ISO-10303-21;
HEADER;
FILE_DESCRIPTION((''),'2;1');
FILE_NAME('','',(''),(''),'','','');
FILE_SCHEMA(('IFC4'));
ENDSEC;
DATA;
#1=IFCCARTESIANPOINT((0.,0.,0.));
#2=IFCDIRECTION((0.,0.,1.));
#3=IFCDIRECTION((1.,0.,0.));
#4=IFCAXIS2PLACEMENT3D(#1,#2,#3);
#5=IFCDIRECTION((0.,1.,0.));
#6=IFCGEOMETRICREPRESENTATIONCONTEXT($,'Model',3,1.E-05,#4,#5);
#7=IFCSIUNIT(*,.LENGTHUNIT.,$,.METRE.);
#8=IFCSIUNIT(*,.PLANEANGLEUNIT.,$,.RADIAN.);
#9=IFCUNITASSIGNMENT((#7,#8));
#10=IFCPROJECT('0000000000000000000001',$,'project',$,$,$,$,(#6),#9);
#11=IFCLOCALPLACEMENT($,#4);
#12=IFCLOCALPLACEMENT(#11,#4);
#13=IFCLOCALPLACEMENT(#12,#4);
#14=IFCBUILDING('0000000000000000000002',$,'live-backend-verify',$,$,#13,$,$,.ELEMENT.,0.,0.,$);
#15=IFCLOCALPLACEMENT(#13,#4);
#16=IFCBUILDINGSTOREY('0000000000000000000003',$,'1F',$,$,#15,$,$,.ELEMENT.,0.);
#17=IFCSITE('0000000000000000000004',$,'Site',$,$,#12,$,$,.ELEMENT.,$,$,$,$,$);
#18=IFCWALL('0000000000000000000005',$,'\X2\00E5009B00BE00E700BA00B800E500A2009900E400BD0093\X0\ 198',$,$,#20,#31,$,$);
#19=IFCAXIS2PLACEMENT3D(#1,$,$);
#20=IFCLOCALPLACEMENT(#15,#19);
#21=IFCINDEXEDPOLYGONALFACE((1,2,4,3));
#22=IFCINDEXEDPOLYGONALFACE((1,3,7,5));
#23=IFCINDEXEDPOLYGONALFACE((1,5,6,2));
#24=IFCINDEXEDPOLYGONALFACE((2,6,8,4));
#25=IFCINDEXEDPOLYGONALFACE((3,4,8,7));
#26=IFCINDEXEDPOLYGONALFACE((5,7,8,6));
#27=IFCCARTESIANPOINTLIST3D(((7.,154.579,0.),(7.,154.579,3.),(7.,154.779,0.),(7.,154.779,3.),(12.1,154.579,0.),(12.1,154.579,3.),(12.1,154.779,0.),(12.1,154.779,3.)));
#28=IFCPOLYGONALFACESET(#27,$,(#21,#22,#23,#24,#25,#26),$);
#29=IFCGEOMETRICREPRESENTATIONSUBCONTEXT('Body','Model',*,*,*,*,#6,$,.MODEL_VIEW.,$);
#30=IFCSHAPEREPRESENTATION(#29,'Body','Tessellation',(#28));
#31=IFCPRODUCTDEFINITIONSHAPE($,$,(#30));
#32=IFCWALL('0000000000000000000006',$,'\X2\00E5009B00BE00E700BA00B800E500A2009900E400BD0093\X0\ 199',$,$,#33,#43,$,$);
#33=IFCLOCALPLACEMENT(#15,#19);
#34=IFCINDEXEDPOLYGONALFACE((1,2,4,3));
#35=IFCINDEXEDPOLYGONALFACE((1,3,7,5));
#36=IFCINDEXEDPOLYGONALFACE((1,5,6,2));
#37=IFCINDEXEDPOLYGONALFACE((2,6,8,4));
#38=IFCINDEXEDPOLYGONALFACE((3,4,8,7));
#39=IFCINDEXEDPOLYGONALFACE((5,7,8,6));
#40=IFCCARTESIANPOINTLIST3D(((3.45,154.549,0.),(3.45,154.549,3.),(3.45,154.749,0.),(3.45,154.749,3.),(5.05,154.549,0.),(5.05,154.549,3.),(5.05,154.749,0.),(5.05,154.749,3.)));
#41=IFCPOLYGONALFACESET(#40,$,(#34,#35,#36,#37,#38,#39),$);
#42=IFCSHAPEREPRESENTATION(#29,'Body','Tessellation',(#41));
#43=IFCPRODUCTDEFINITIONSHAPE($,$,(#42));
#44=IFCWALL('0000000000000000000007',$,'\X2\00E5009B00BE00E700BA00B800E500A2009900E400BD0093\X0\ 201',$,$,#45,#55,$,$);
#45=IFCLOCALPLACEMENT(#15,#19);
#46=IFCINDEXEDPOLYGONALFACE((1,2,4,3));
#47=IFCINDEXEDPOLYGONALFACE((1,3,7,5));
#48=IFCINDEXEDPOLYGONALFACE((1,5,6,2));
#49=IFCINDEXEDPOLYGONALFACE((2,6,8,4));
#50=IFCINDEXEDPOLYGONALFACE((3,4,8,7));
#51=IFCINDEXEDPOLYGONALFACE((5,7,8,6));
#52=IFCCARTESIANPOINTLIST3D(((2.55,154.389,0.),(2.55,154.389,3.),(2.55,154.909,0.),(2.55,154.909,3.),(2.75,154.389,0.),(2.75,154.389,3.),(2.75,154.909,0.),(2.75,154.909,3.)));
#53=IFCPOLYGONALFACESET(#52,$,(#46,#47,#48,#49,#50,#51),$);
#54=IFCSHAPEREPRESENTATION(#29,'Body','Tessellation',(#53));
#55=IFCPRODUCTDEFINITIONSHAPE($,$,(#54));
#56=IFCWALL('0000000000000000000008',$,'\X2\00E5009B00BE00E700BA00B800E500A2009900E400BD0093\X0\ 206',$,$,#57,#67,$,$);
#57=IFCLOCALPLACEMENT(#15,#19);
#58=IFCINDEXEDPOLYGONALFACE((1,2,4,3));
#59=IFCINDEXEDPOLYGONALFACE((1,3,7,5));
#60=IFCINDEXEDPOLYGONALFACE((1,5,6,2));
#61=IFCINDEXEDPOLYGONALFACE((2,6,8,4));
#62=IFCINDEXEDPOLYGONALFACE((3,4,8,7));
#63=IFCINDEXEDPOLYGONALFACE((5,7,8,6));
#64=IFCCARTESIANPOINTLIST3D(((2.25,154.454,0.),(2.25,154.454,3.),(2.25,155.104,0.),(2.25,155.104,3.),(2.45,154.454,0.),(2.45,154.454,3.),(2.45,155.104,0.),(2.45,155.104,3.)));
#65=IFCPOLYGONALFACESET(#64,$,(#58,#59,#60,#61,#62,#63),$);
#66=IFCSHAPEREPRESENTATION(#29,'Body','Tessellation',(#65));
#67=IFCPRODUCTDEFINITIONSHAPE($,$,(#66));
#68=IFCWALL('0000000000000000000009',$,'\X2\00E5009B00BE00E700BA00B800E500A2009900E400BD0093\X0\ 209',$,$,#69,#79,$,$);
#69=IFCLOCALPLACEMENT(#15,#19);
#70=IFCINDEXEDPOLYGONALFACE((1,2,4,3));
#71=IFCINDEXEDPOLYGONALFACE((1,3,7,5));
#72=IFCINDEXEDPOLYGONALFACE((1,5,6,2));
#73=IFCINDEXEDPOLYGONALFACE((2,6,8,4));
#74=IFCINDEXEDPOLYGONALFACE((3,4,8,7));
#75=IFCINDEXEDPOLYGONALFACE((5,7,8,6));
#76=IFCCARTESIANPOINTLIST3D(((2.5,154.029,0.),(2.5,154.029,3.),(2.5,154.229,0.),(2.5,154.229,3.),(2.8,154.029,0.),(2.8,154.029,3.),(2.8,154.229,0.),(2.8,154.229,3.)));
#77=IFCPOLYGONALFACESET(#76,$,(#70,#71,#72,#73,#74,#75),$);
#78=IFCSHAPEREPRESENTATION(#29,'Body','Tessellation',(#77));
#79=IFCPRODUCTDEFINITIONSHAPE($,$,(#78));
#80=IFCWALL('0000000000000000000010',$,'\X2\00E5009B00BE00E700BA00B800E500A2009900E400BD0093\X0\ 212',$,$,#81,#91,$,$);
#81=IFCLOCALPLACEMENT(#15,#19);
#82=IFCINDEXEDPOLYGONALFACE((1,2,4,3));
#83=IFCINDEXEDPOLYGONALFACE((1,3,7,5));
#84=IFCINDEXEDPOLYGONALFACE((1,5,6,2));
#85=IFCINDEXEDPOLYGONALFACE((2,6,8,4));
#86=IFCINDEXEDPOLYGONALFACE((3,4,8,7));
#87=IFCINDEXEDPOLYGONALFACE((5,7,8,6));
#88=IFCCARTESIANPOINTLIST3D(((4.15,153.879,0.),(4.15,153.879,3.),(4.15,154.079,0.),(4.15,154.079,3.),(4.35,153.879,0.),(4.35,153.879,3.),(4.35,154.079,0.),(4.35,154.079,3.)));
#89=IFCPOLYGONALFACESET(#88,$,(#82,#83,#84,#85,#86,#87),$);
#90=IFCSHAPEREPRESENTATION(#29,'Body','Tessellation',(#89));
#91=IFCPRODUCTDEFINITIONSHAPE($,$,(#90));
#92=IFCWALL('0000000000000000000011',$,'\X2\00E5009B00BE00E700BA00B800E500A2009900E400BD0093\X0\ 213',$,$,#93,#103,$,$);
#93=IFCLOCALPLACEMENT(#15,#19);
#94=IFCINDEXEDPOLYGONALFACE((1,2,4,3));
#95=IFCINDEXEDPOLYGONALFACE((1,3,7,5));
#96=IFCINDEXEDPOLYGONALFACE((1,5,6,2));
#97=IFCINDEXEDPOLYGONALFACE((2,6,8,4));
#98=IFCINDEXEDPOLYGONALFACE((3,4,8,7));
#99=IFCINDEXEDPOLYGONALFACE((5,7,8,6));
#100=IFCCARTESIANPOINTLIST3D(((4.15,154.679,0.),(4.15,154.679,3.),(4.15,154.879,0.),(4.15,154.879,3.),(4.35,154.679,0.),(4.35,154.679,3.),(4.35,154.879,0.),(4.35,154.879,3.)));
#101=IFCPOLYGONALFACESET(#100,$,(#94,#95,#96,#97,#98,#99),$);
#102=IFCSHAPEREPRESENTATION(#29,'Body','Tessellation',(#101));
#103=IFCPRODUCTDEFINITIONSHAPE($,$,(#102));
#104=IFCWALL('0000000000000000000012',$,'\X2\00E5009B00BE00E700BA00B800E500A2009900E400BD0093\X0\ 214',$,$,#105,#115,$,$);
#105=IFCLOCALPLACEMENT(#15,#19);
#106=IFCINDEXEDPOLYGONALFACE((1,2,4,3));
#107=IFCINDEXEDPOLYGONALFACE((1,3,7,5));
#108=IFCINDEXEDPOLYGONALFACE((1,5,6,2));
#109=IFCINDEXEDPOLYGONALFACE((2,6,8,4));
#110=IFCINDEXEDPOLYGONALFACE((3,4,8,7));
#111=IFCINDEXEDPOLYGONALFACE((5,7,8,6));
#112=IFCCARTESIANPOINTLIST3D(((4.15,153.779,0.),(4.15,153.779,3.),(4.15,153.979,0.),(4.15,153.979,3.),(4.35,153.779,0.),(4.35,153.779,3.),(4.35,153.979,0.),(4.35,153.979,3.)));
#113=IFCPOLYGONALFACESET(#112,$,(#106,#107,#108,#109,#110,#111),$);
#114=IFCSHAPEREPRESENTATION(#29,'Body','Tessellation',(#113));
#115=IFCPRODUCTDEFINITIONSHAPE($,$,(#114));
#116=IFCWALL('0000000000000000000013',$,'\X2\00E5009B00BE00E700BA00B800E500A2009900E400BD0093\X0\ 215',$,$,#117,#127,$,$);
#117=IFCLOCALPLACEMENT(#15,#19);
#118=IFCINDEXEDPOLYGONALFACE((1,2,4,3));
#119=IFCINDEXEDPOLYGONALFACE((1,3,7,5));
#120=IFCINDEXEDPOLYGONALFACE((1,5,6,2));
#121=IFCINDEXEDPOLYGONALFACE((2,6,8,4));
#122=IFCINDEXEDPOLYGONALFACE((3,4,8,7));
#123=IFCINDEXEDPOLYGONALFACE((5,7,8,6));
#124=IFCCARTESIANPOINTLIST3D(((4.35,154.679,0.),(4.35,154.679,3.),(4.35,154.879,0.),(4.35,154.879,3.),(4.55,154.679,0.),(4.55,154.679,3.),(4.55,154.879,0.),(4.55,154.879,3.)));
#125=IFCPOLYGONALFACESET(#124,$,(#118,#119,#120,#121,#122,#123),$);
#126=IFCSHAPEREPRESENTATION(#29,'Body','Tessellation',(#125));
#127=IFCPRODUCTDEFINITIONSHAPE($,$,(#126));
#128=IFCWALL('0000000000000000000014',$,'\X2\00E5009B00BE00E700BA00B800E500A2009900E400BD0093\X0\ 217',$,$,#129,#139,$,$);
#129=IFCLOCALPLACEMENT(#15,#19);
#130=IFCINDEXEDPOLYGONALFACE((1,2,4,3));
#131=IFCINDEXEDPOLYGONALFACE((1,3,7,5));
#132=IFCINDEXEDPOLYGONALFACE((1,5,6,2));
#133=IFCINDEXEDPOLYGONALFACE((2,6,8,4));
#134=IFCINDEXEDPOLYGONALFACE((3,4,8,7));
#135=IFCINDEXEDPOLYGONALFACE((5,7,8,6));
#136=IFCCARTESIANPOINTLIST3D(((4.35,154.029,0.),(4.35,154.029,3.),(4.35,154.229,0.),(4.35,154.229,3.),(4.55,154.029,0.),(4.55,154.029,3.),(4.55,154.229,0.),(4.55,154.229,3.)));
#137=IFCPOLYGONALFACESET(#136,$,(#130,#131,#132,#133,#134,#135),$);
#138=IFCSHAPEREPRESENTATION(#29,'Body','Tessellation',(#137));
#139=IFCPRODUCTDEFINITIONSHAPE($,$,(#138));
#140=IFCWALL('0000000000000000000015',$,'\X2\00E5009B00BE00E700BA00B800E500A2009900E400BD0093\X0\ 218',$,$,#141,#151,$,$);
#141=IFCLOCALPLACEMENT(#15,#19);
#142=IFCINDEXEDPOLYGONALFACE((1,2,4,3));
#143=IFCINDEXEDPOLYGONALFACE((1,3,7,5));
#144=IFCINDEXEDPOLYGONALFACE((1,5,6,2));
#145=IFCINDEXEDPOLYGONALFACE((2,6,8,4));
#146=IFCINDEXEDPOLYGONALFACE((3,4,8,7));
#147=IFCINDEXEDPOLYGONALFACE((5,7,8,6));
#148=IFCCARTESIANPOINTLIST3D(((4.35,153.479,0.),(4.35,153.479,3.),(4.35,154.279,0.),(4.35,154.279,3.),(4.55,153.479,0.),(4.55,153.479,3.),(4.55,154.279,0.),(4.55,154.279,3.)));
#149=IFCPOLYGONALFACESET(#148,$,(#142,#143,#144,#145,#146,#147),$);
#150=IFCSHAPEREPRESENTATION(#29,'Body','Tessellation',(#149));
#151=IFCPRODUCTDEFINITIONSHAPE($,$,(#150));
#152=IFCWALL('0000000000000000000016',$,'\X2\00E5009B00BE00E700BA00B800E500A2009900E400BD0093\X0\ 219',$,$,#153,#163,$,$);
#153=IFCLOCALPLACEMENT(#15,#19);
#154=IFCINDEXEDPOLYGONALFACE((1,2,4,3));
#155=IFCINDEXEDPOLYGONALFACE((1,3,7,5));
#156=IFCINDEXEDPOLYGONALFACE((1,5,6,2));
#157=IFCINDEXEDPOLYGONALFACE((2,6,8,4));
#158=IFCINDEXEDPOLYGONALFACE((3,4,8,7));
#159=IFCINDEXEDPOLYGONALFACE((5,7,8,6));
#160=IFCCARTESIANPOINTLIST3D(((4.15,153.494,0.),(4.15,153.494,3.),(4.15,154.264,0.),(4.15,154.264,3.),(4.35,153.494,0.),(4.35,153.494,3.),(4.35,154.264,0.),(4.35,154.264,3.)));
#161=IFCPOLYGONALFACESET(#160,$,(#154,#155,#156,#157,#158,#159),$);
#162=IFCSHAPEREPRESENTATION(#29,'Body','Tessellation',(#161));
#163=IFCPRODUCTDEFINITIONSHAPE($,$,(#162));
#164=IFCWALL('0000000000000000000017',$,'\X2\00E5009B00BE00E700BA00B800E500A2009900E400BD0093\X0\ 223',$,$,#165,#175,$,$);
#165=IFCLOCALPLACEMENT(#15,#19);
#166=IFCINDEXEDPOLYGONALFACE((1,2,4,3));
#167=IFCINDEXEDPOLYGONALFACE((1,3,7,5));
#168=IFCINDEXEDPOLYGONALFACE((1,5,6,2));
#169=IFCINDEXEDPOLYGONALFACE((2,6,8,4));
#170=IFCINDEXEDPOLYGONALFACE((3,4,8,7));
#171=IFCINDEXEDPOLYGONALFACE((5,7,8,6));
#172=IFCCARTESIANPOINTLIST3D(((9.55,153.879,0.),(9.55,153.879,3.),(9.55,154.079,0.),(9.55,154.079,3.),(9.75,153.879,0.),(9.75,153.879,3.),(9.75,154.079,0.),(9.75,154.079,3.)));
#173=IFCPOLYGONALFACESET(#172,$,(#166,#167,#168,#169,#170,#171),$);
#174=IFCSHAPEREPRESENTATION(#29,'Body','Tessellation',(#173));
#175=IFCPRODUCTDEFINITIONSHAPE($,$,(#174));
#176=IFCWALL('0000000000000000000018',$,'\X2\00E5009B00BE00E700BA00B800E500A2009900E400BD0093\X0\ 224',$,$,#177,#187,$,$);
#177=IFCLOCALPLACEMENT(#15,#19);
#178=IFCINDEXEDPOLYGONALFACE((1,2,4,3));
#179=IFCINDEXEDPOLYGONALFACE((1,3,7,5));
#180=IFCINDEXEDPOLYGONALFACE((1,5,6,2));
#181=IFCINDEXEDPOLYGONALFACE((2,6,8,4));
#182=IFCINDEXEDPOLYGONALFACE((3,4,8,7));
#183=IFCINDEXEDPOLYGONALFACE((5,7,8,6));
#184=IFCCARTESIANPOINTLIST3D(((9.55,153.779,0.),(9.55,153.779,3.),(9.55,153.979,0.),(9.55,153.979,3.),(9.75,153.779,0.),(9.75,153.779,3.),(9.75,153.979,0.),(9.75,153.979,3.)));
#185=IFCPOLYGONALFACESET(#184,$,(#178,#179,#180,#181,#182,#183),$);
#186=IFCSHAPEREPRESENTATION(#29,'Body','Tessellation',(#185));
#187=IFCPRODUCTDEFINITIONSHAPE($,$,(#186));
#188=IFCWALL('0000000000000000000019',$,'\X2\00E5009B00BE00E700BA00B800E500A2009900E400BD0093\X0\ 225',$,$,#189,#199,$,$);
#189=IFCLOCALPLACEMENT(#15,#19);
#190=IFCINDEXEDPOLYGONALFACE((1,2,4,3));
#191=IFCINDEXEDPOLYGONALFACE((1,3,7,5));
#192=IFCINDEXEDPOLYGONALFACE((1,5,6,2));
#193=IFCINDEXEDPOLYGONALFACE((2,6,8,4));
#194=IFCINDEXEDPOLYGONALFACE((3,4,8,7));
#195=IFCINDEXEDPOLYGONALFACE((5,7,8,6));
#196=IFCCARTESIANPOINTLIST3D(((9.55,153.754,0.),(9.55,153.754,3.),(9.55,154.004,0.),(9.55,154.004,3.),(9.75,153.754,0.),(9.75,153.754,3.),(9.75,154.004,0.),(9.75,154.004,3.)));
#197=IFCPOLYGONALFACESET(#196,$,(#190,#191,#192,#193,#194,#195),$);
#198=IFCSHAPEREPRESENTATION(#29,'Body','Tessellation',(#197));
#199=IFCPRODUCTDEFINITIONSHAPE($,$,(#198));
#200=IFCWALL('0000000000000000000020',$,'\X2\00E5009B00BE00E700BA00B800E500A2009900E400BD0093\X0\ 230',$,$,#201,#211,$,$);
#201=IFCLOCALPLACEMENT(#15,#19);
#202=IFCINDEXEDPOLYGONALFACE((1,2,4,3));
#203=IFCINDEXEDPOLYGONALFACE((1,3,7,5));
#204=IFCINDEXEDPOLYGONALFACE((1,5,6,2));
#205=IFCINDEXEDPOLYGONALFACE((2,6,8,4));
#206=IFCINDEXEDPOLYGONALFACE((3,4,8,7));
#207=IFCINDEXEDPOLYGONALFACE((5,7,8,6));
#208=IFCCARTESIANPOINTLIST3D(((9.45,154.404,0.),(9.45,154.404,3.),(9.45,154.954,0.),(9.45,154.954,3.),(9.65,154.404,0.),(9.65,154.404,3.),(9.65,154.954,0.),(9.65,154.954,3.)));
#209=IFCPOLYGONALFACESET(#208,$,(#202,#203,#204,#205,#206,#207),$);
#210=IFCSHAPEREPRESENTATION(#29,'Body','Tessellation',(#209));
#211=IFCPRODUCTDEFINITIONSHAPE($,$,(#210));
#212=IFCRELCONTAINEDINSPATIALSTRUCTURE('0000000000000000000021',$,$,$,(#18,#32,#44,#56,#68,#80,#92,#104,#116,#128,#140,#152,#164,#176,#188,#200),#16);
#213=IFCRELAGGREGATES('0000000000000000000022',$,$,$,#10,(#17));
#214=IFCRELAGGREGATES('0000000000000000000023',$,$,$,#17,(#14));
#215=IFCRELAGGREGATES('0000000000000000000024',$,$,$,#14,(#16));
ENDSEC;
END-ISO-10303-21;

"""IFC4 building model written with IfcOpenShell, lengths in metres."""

from ifc_helpers import new_model, si_unit, direction, frame, frame_2d, origin_with_axes, place, context, subcontext, project, spatial, rectangle, extrude, element, save


model = new_model("IFC4")

# Units and contexts
model_context = context("Model", 3, precision=1e-05, world=origin_with_axes(), true_north=direction((0.0, 1.0, 0.0)))
body_context = subcontext(model_context, "Body", "Model", "MODEL_VIEW")
ifc_project = project(units=[si_unit("LENGTHUNIT", "METRE"), si_unit("PLANEANGLEUNIT", "RADIAN")], contexts=[model_context])

# Site, building, storey
placement = place(None, origin_with_axes())
site_placement = place(placement, origin_with_axes())
site = spatial("IfcSite", under=ifc_project, at=site_placement, Name="Site", CompositionType="ELEMENT")
building_placement = place(site_placement, origin_with_axes())
building = spatial("IfcBuilding", under=site, at=building_placement, Name="live-backend-verify", CompositionType="ELEMENT", ElevationOfRefHeight=0.0, ElevationOfTerrain=0.0)
storey_placement = place(building_placement, origin_with_axes())
storey = spatial("IfcBuildingStorey", under=building, at=storey_placement, Name="1F", CompositionType="ELEMENT", Elevation=0.0)

# Walls
wall_1_placement = place(storey_placement, frame((9.55, 154.679, 0.0), z_axis=(0.0, 0.0, 1.0), x_axis=(-1.0, 0.0, 0.0)))
element("IfcWall", 1, at=wall_1_placement, inside=storey, Name="å\u009b¾çº¸å¢\u0099ä½\u0093 198", context=body_context, shape_type="SweptSolid", body=[
    extrude(rectangle(XDim=5.1, YDim=0.2, at=frame_2d((0.0, 0.0), x_axis=(1.0, 0.0, 0.0))), frame((0.0, 0.0, 0.0), z_axis=(0.0, 0.0, 1.0)), (0.0, 0.0, 1.0), 3.0),
])
wall_2_placement = place(storey_placement, frame((4.25, 154.649, 0.0), z_axis=(0.0, 0.0, 1.0), x_axis=(-1.0, 0.0, 0.0)))
element("IfcWall", 2, at=wall_2_placement, inside=storey, Name="å\u009b¾çº¸å¢\u0099ä½\u0093 199", context=body_context, shape_type="SweptSolid", body=[
    extrude(rectangle(XDim=1.6, YDim=0.2, at=frame_2d((0.0, 0.0), x_axis=(1.0, 0.0, 0.0))), frame((0.0, 0.0, 0.0), z_axis=(0.0, 0.0, 1.0)), (0.0, 0.0, 1.0), 3.0),
])
wall_3_placement = place(storey_placement, frame((2.65, 154.649, 0.0), z_axis=(0.0, 0.0, 1.0), x_axis=(0.0, -1.0, 0.0)))
element("IfcWall", 3, at=wall_3_placement, inside=storey, Name="å\u009b¾çº¸å¢\u0099ä½\u0093 201", context=body_context, shape_type="SweptSolid", body=[
    extrude(rectangle(XDim=0.52, YDim=0.2, at=frame_2d((0.0, 0.0), x_axis=(1.0, 0.0, 0.0))), frame((0.0, 0.0, 0.0), z_axis=(0.0, 0.0, 1.0)), (0.0, 0.0, 1.0), 3.0),
])
wall_4_placement = place(storey_placement, frame((2.35, 154.779, 0.0), z_axis=(0.0, 0.0, 1.0), x_axis=(0.0, -1.0, 0.0)))
element("IfcWall", 4, at=wall_4_placement, inside=storey, Name="å\u009b¾çº¸å¢\u0099ä½\u0093 206", context=body_context, shape_type="SweptSolid", body=[
    extrude(rectangle(XDim=0.65, YDim=0.2, at=frame_2d((0.0, 0.0), x_axis=(1.0, 0.0, 0.0))), frame((0.0, 0.0, 0.0), z_axis=(0.0, 0.0, 1.0)), (0.0, 0.0, 1.0), 3.0),
])
wall_5_placement = place(storey_placement, frame((2.65, 154.129, 0.0), z_axis=(0.0, 0.0, 1.0), x_axis=(-1.0, 0.0, 0.0)))
element("IfcWall", 5, at=wall_5_placement, inside=storey, Name="å\u009b¾çº¸å¢\u0099ä½\u0093 209", context=body_context, shape_type="SweptSolid", body=[
    extrude(rectangle(XDim=0.3, YDim=0.2, at=frame_2d((0.0, 0.0), x_axis=(1.0, 0.0, 0.0))), frame((0.0, 0.0, 0.0), z_axis=(0.0, 0.0, 1.0)), (0.0, 0.0, 1.0), 3.0),
])
for number, where, z_axis, x_axis, name in (
    (6, (4.25, 153.979, 0.0), (0.0, 0.0, 1.0), (1.0, 0.0, 0.0), "å\u009b¾çº¸å¢\u0099ä½\u0093 212"),
    (7, (4.25, 154.779, 0.0), (0.0, 0.0, 1.0), (1.0, 0.0, 0.0), "å\u009b¾çº¸å¢\u0099ä½\u0093 213"),
    (8, (4.25, 153.879, 0.0), (0.0, 0.0, 1.0), (1.0, 0.0, 0.0), "å\u009b¾çº¸å¢\u0099ä½\u0093 214"),
    (9, (4.45, 154.779, 0.0), (0.0, 0.0, 1.0), (-1.0, 0.0, 0.0), "å\u009b¾çº¸å¢\u0099ä½\u0093 215"),
    (10, (4.45, 154.129, 0.0), (0.0, 0.0, 1.0), (-1.0, 0.0, 0.0), "å\u009b¾çº¸å¢\u0099ä½\u0093 217"),
):
    element("IfcWall", number, at=place(storey_placement, frame(where, z_axis=z_axis, x_axis=x_axis)), inside=storey, Name=name, context=body_context, shape_type="SweptSolid", body=[
        extrude(rectangle(XDim=0.2, YDim=0.2, at=frame_2d((0.0, 0.0), x_axis=(1.0, 0.0, 0.0))), frame((0.0, 0.0, 0.0), z_axis=(0.0, 0.0, 1.0)), (0.0, 0.0, 1.0), 3.0),
    ])
wall_6_placement = place(storey_placement, frame((4.45, 153.879, 0.0), z_axis=(0.0, 0.0, 1.0), x_axis=(0.0, 1.0, 0.0)))
element("IfcWall", 11, at=wall_6_placement, inside=storey, Name="å\u009b¾çº¸å¢\u0099ä½\u0093 218", context=body_context, shape_type="SweptSolid", body=[
    extrude(rectangle(XDim=0.8, YDim=0.2, at=frame_2d((0.0, 0.0), x_axis=(1.0, 0.0, 0.0))), frame((0.0, 0.0, 0.0), z_axis=(0.0, 0.0, 1.0)), (0.0, 0.0, 1.0), 3.0),
])
wall_7_placement = place(storey_placement, frame((4.25, 153.879, 0.0), z_axis=(0.0, 0.0, 1.0), x_axis=(0.0, 1.0, 0.0)))
element("IfcWall", 12, at=wall_7_placement, inside=storey, Name="å\u009b¾çº¸å¢\u0099ä½\u0093 219", context=body_context, shape_type="SweptSolid", body=[
    extrude(rectangle(XDim=0.77, YDim=0.2, at=frame_2d((0.0, 0.0), x_axis=(1.0, 0.0, 0.0))), frame((0.0, 0.0, 0.0), z_axis=(0.0, 0.0, 1.0)), (0.0, 0.0, 1.0), 3.0),
])
for number, where, z_axis, x_axis, name in (
    (13, (9.65, 153.979, 0.0), (0.0, 0.0, 1.0), (1.0, 0.0, 0.0), "å\u009b¾çº¸å¢\u0099ä½\u0093 223"),
    (14, (9.65, 153.879, 0.0), (0.0, 0.0, 1.0), (1.0, 0.0, 0.0), "å\u009b¾çº¸å¢\u0099ä½\u0093 224"),
):
    element("IfcWall", number, at=place(storey_placement, frame(where, z_axis=z_axis, x_axis=x_axis)), inside=storey, Name=name, context=body_context, shape_type="SweptSolid", body=[
        extrude(rectangle(XDim=0.2, YDim=0.2, at=frame_2d((0.0, 0.0), x_axis=(1.0, 0.0, 0.0))), frame((0.0, 0.0, 0.0), z_axis=(0.0, 0.0, 1.0)), (0.0, 0.0, 1.0), 3.0),
    ])
wall_8_placement = place(storey_placement, frame((9.65, 153.879, 0.0), z_axis=(0.0, 0.0, 1.0), x_axis=(0.0, 1.0, 0.0)))
element("IfcWall", 15, at=wall_8_placement, inside=storey, Name="å\u009b¾çº¸å¢\u0099ä½\u0093 225", context=body_context, shape_type="SweptSolid", body=[
    extrude(rectangle(XDim=0.25, YDim=0.2, at=frame_2d((0.0, 0.0), x_axis=(1.0, 0.0, 0.0))), frame((0.0, 0.0, 0.0), z_axis=(0.0, 0.0, 1.0)), (0.0, 0.0, 1.0), 3.0),
])
wall_9_placement = place(storey_placement, frame((9.55, 154.679, 0.0), z_axis=(0.0, 0.0, 1.0), x_axis=(0.0, -1.0, 0.0)))
element("IfcWall", 16, at=wall_9_placement, inside=storey, Name="å\u009b¾çº¸å¢\u0099ä½\u0093 230", context=body_context, shape_type="SweptSolid", body=[
    extrude(rectangle(XDim=0.55, YDim=0.2, at=frame_2d((0.0, 0.0), x_axis=(1.0, 0.0, 0.0))), frame((0.0, 0.0, 0.0), z_axis=(0.0, 0.0, 1.0)), (0.0, 0.0, 1.0), 3.0),
])

save(model, "model.ifc")
